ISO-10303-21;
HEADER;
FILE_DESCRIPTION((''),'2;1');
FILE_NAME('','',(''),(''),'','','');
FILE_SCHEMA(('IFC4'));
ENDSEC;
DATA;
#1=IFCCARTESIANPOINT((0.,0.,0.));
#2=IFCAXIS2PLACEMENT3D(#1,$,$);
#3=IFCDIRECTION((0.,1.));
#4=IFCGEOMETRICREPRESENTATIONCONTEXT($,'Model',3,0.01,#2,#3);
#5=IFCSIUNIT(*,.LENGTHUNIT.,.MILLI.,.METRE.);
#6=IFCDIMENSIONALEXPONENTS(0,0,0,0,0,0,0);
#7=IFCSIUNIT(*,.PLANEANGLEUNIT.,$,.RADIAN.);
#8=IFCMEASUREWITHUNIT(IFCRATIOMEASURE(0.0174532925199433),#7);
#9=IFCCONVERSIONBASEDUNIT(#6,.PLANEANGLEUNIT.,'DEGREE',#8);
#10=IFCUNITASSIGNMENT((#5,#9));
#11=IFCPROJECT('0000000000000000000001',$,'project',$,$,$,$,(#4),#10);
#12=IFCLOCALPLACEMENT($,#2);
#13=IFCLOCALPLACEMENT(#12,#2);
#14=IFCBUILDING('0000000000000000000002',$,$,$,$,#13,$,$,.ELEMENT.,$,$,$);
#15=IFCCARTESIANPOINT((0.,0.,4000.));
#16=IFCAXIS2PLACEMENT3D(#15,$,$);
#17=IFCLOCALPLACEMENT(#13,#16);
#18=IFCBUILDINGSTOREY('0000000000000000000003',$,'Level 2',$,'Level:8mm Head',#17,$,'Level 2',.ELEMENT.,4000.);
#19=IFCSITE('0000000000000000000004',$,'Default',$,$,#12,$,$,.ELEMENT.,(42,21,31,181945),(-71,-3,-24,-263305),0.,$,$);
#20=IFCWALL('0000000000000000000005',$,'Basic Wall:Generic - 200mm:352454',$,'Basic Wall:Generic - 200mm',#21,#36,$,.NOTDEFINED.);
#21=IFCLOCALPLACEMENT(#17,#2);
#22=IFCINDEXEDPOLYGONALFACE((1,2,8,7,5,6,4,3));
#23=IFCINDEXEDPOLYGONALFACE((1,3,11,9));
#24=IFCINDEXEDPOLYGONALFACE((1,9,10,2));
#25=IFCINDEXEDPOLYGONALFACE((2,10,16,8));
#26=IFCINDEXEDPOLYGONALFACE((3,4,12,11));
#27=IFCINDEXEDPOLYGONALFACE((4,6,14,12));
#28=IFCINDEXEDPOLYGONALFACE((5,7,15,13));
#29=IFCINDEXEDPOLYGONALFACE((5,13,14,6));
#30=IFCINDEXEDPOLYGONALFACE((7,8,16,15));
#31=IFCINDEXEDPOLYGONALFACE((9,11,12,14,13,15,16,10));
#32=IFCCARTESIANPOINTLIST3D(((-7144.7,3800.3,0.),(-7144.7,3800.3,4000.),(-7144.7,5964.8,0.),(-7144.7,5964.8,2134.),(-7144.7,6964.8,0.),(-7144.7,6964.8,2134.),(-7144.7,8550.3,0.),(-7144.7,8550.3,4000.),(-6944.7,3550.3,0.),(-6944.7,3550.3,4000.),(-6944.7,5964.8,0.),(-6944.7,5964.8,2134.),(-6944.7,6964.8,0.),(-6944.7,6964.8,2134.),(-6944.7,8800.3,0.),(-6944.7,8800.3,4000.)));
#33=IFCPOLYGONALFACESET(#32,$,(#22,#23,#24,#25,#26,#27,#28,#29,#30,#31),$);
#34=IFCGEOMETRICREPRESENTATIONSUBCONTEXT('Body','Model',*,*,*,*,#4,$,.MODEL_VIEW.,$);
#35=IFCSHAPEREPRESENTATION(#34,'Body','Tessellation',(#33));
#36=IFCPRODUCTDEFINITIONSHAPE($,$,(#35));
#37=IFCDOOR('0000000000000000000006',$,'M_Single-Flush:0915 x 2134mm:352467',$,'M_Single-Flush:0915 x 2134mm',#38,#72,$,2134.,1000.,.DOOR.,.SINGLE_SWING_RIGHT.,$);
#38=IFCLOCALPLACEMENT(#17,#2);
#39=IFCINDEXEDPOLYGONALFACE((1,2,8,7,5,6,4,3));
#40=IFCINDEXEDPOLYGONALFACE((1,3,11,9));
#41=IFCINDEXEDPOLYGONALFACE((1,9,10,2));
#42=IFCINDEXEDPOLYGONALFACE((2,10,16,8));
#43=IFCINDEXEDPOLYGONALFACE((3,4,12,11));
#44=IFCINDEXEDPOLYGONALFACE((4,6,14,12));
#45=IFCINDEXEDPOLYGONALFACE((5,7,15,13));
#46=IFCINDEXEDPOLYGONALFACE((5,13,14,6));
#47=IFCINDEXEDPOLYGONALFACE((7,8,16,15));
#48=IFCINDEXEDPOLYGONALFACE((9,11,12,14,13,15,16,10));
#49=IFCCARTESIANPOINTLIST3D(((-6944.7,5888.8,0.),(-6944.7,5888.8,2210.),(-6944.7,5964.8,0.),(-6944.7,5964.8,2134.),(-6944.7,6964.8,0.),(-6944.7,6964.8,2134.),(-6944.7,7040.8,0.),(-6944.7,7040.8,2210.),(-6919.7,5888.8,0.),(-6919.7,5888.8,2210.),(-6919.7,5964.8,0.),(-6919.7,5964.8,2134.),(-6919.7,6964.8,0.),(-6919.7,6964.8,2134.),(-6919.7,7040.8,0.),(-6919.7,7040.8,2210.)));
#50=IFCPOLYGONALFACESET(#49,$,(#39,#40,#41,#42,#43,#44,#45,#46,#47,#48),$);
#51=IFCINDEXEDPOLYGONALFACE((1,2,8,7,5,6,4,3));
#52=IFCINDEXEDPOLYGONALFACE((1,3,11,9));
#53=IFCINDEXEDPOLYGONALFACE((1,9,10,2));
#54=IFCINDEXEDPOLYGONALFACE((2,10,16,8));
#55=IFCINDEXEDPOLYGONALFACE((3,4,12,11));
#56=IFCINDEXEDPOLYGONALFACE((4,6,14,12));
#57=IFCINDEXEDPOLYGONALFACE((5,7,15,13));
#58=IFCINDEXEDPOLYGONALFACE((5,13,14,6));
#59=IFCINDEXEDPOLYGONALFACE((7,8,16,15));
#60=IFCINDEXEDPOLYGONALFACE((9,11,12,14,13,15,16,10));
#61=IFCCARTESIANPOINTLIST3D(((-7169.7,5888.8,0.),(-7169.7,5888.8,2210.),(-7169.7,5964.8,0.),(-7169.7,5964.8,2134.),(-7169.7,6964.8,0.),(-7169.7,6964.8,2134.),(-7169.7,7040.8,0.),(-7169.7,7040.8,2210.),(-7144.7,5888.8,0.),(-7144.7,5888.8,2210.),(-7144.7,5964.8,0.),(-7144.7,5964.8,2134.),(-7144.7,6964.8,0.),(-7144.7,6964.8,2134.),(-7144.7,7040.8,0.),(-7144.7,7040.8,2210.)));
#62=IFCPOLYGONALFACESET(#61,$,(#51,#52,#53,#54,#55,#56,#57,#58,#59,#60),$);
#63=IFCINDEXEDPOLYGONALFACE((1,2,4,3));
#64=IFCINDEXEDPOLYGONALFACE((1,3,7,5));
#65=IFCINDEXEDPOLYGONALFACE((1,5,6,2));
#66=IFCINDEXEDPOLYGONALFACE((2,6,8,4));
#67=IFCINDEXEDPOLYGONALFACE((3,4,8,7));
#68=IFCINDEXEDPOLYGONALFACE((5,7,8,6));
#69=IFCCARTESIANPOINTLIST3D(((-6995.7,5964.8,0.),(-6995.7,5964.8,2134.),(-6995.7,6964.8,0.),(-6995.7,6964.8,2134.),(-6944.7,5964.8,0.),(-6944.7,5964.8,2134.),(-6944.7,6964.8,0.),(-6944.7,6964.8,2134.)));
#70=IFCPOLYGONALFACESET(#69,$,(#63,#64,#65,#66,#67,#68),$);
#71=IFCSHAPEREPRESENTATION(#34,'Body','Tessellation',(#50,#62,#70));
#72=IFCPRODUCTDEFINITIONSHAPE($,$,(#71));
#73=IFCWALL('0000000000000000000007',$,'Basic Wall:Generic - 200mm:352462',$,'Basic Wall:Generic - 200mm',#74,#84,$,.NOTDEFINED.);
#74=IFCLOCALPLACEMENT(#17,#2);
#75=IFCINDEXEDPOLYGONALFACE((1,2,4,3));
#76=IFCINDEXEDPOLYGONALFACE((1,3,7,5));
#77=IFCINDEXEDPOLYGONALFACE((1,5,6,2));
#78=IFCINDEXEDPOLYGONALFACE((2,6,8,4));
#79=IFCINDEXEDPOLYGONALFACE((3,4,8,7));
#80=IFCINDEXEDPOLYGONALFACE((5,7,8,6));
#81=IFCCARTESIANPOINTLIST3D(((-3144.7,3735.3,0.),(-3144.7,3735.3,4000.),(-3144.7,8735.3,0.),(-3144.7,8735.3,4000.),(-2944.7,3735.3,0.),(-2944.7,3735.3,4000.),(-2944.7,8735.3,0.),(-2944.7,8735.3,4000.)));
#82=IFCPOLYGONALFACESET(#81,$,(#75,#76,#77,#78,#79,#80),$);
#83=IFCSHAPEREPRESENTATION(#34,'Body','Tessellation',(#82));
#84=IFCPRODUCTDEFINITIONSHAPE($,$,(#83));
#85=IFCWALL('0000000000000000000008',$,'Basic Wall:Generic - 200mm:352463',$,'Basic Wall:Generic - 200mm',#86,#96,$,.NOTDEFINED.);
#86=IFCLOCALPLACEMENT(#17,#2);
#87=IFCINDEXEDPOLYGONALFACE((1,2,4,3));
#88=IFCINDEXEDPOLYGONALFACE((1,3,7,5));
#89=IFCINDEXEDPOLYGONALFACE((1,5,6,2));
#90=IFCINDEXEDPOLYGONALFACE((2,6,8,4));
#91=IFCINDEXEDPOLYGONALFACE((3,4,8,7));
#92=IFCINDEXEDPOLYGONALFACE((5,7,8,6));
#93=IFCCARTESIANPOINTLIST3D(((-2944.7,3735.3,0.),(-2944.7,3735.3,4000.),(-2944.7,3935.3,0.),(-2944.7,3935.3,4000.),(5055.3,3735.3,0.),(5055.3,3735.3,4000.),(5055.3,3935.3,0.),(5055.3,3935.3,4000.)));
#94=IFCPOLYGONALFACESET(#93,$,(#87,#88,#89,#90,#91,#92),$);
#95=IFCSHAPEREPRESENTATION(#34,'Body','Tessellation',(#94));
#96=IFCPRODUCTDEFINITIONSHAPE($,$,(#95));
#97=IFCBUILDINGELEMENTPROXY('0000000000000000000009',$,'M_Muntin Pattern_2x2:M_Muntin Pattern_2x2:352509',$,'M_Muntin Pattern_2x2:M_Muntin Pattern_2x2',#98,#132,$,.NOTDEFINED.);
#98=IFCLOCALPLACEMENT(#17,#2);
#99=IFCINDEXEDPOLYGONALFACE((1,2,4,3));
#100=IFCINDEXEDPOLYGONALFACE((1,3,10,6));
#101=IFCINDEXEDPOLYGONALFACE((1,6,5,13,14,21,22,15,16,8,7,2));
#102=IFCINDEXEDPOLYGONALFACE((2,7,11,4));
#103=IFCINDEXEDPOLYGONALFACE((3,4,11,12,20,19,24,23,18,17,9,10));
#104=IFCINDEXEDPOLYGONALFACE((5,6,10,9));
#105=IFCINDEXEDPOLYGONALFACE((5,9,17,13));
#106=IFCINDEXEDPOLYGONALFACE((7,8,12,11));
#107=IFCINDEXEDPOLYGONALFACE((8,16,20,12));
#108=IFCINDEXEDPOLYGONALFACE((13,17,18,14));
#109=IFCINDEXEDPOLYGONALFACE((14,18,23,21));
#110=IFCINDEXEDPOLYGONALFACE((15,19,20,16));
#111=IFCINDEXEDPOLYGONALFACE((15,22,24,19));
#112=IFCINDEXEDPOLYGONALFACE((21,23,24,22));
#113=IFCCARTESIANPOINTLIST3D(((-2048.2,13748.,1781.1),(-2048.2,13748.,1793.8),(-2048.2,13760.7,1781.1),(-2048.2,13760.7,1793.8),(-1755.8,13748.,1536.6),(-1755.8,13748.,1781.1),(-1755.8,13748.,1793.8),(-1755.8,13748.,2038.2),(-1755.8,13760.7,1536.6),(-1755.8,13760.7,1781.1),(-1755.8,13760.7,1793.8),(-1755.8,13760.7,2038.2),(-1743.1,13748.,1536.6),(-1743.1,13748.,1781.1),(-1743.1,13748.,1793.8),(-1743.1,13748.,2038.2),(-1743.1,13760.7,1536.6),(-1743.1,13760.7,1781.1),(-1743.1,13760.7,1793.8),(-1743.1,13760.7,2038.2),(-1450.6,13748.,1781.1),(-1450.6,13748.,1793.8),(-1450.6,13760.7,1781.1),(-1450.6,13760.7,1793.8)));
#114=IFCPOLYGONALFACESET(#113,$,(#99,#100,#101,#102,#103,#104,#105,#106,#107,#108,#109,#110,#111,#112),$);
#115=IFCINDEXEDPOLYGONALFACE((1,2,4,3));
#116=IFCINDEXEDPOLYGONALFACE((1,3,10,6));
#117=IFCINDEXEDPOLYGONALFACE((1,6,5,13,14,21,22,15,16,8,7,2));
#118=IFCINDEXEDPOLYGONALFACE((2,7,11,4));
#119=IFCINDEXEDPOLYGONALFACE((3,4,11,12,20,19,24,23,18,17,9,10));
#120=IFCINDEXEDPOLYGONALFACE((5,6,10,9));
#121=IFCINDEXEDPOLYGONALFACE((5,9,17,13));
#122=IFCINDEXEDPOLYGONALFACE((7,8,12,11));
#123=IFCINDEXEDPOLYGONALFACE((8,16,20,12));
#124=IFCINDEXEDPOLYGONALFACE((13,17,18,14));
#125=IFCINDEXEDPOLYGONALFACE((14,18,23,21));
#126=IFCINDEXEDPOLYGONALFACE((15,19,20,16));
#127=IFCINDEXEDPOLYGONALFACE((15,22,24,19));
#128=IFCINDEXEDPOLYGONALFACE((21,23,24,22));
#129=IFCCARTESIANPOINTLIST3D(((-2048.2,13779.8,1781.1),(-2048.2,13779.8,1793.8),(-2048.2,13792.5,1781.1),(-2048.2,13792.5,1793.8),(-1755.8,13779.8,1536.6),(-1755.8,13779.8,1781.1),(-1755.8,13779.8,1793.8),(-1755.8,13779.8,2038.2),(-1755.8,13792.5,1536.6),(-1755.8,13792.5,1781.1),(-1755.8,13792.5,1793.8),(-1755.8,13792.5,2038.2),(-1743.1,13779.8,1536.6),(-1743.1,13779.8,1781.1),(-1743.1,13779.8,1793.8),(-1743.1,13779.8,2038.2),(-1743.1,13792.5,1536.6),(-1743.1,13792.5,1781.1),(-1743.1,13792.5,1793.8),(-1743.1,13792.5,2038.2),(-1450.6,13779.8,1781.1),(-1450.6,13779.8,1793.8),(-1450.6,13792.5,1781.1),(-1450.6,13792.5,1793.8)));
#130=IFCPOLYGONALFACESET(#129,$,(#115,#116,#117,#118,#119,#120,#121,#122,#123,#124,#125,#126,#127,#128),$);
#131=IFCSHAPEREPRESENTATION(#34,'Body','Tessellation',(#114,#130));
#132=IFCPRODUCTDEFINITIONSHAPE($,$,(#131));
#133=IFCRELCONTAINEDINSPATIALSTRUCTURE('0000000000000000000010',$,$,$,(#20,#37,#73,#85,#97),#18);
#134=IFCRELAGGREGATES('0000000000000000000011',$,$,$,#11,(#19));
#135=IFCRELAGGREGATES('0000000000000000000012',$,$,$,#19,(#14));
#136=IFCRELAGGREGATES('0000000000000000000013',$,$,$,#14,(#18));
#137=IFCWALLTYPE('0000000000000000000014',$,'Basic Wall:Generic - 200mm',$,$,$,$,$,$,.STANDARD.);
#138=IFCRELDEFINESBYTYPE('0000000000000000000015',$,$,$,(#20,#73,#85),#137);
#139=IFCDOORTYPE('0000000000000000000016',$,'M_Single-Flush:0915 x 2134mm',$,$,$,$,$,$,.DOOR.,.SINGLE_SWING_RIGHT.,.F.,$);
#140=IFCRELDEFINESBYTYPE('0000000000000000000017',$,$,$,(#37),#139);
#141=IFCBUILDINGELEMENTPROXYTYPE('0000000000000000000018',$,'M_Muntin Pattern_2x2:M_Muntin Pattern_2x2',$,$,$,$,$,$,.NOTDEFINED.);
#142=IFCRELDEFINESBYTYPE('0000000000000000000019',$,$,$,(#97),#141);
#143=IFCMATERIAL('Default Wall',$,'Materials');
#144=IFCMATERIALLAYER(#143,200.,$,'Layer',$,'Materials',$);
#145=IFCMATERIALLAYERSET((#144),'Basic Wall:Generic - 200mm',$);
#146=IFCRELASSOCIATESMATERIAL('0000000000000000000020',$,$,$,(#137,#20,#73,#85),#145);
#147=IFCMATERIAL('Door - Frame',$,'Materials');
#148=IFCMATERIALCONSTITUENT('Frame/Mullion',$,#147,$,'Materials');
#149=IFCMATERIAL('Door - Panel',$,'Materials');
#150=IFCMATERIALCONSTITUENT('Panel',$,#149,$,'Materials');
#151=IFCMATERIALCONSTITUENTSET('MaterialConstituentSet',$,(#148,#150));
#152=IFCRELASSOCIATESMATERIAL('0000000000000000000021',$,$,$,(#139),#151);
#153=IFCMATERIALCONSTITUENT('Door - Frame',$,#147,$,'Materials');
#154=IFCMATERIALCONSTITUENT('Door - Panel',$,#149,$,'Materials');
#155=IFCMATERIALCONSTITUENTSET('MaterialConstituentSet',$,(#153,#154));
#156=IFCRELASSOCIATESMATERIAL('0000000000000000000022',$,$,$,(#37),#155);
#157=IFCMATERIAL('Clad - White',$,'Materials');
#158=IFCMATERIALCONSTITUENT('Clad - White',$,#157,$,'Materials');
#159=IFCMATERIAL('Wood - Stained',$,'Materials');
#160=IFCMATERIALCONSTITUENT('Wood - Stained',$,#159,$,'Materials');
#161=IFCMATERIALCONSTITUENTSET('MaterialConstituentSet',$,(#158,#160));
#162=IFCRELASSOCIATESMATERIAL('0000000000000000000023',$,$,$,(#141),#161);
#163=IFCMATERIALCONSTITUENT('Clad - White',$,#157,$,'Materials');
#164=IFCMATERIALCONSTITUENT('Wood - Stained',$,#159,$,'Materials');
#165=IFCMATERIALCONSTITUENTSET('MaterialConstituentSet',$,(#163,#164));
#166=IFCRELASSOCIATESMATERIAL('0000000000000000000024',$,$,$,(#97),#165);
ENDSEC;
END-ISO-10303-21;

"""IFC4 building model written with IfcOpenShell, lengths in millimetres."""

from ifc_helpers import new_model, entity, si_unit, converted_unit, direction, frame, frame_2d, origin, place, context, subcontext, project, spatial, polyline, rectangle, outline, extrude, source, transform, mapped, material, layer, layer_set, layer_usage, constituent, constituent_set, type_object, type_shapes, element, fill, save


model = new_model("IFC4")

# Units and contexts
model_context = context("Model", 3, precision=0.01, world=origin(), true_north=direction((0.0, 1.0)))
body_context = subcontext(model_context, "Body", "Model", "MODEL_VIEW")
ifc_project = project(units=[si_unit("LENGTHUNIT", "METRE", prefix="MILLI"), converted_unit("PLANEANGLEUNIT", "DEGREE", entity("IfcRatioMeasure", 0.0174532925199433), si_unit("PLANEANGLEUNIT", "RADIAN"), dimensions=[0, 0, 0, 0, 0, 0, 0])], contexts=[model_context])

# Site, building, storey
site_placement = place(None, origin())
site = spatial("IfcSite", under=ifc_project, at=site_placement, Name="Default", CompositionType="ELEMENT", RefLatitude=(42, 21, 31, 181945), RefLongitude=(-71, -3, -24, -263305), RefElevation=0.0)
building_placement = place(site_placement, origin())
building = spatial("IfcBuilding", under=site, at=building_placement, CompositionType="ELEMENT")
storey_placement = place(building_placement, frame((0.0, 0.0, 4000.0)))
storey = spatial("IfcBuildingStorey", under=building, at=storey_placement, Name="Level 2", ObjectType="Level:8mm Head", LongName="Level 2", CompositionType="ELEMENT", Elevation=4000.0)

# Shared definitions
ifc_material_1 = material(Name="Default Wall", Category="Materials")
ifc_layer = layer(ifc_material_1, 200.0, Name="Layer", Category="Materials")
ifc_layer_set = layer_set([ifc_layer], Name="Basic Wall:Generic - 200mm")
wall_type = type_object("IfcWallType", Name="Basic Wall:Generic - 200mm", PredefinedType="STANDARD", material=ifc_layer_set)
ifc_material_2 = material(Name="Door - Frame", Category="Materials")
ifc_material_3 = material(Name="Door - Panel", Category="Materials")
ifc_constituent_1 = constituent(ifc_material_2, Name="Frame/Mullion", Category="Materials")
ifc_constituent_2 = constituent(ifc_material_3, Name="Panel", Category="Materials")
ifc_constituent_set_1 = constituent_set(constituents=[ifc_constituent_1, ifc_constituent_2], Name="MaterialConstituentSet")
door_type = type_object("IfcDoorType", Name="M_Single-Flush:0915 x 2134mm", OperationType="SINGLE_SWING_RIGHT", ParameterTakesPrecedence=False, PredefinedType="DOOR", material=ifc_constituent_set_1)
shared_shape_1 = source(origin(), body_context, "Body", "SweptSolid", [
    extrude(outline(polyline([(-576.0, -1124.0), (576.0, -1124.0), (576.0, 1086.0), (500.0, 1086.0), (500.0, -1048.0), (-500.0, -1048.0), (-500.0, 1086.0), (-576.0, 1086.0), (-576.0, -1124.0)])), frame((500.0, 200.0, 1086.0), z_axis=(0.0, 1.0, 0.0), x_axis=(1.0, 0.0, 0.0)), (0.0, 0.0, 1.0), 25.0),
    extrude(outline(polyline([(-1124.0, -576.0), (1086.0, -576.0), (1086.0, -500.0), (-1048.0, -500.0), (-1048.0, 500.0), (1086.0, 500.0), (1086.0, 576.0), (-1124.0, 576.0), (-1124.0, -576.0)])), frame((500.0, -25.0, 1086.0), z_axis=(0.0, 1.0, 0.0), x_axis=(0.0, 0.0, -1.0)), (0.0, 0.0, 1.0), 25.0),
    extrude(rectangle(XDim=51.0, YDim=1000.0, at=frame_2d((0.0, 0.0), x_axis=(1.0, 0.0))), frame((500.0, 174.5, 0.0), z_axis=(0.0, 0.0, 1.0), x_axis=(0.0, 1.0, 0.0)), (0.0, 0.0, 1.0), 2134.0),
])
type_shapes(door_type, [shared_shape_1])
ifc_material_4 = material(Name="Wood - Stained", Category="Materials")

# Wall, opening, door
ifc_layer_usage_1 = layer_usage(ifc_layer_set, "AXIS2", "NEGATIVE", 100.0)
wall_1_placement = place(storey_placement, frame((-7044.7, 8800.3, 0.0), z_axis=(0.0, 0.0, 1.0), x_axis=(0.0, -1.0, 0.0)))
wall_1 = element("IfcWall", 1, at=wall_1_placement, inside=storey, type_object=wall_type, material=ifc_layer_usage_1, Name="Basic Wall:Generic - 200mm:352454", ObjectType="Basic Wall:Generic - 200mm", PredefinedType="NOTDEFINED", context=body_context, shape_type="SweptSolid", body=[
    extrude(outline(polyline([(250.0, -100.0), (5000.0, -100.0), (5250.0, 100.0), (4929.8, 100.0), (0.0, 100.0), (250.0, -100.0)])), origin(), (0.0, 0.0, 1.0), 4000.0),
])
opening_1_placement = place(wall_1_placement, frame((1835.4, -100.0, 0.0)))
opening_1 = element("IfcOpeningElement", 2, at=opening_1_placement, cuts=wall_1, PredefinedType="OPENING", context=body_context, shape_type="SweptSolid", body=[
    extrude(rectangle(XDim=1000.0, YDim=2134.0, at=frame_2d((1067.0, 500.0), x_axis=(0.0, 1.0))), frame((0.0, 0.0, 0.0), z_axis=(0.0, 1.0, 0.0), x_axis=(0.0, 0.0, 1.0)), (0.0, 0.0, 1.0), 200.0),
])
ifc_constituent_3 = constituent(ifc_material_2, Name="Door - Frame", Category="Materials")
ifc_constituent_4 = constituent(ifc_material_3, Name="Door - Panel", Category="Materials")
ifc_constituent_set_2 = constituent_set(constituents=[ifc_constituent_3, ifc_constituent_4], Name="MaterialConstituentSet")
door_1_placement = place(opening_1_placement, origin())
door_1 = element("IfcDoor", 3, at=door_1_placement, inside=storey, type_object=door_type, material=ifc_constituent_set_2, Name="M_Single-Flush:0915 x 2134mm:352467", ObjectType="M_Single-Flush:0915 x 2134mm", OperationType="SINGLE_SWING_RIGHT", OverallHeight=2134.0, OverallWidth=1000.0, PredefinedType="DOOR", context=body_context, shape_type="MappedRepresentation", body=[
    mapped(shared_shape_1, transform((0.0, 0.0, 0.0), scale=1.0)),
])
fill(opening_1, door_1)

# Walls
ifc_layer_usage_2 = layer_usage(ifc_layer_set, "AXIS2", "NEGATIVE", 100.0)
wall_2_placement = place(storey_placement, frame((-3044.7, 8735.3, 0.0), z_axis=(0.0, 0.0, 1.0), x_axis=(0.0, -1.0, 0.0)))
element("IfcWall", 4, at=wall_2_placement, inside=storey, type_object=wall_type, material=ifc_layer_usage_2, Name="Basic Wall:Generic - 200mm:352462", ObjectType="Basic Wall:Generic - 200mm", PredefinedType="NOTDEFINED", context=body_context, shape_type="SweptSolid", body=[
    extrude(rectangle(XDim=5000.0, YDim=200.0, at=frame_2d((2500.0, 0.0), x_axis=(-1.0, 0.0))), origin(), (0.0, 0.0, 1.0), 4000.0),
])
ifc_layer_usage_3 = layer_usage(ifc_layer_set, "AXIS2", "NEGATIVE", 100.0)
wall_3_placement = place(storey_placement, frame((-2944.7, 3835.3, 0.0)))
element("IfcWall", 5, at=wall_3_placement, inside=storey, type_object=wall_type, material=ifc_layer_usage_3, Name="Basic Wall:Generic - 200mm:352463", ObjectType="Basic Wall:Generic - 200mm", PredefinedType="NOTDEFINED", context=body_context, shape_type="SweptSolid", body=[
    extrude(rectangle(XDim=8000.0, YDim=200.0, at=frame_2d((4000.0, 0.0), x_axis=(-1.0, 0.0))), origin(), (0.0, 0.0, 1.0), 4000.0),
])

# Building element proxy
ifc_material_5 = material(Name="Clad - White", Category="Materials")
ifc_constituent_5 = constituent(ifc_material_5, Name="Clad - White", Category="Materials")
ifc_constituent_6 = constituent(ifc_material_4, Name="Wood - Stained", Category="Materials")
ifc_constituent_set_3 = constituent_set(constituents=[ifc_constituent_5, ifc_constituent_6], Name="MaterialConstituentSet")
ifc_constituent_7 = constituent(ifc_material_5, Name="Clad - White", Category="Materials")
ifc_constituent_8 = constituent(ifc_material_4, Name="Wood - Stained", Category="Materials")
ifc_constituent_set_4 = constituent_set(constituents=[ifc_constituent_7, ifc_constituent_8], Name="MaterialConstituentSet")
building_element_proxy_type_1 = type_object("IfcBuildingElementProxyType", Name="M_Muntin Pattern_2x2:M_Muntin Pattern_2x2", PredefinedType="NOTDEFINED", material=ifc_constituent_set_4)
shared_shape_2 = source(origin(), body_context, "Body", "SweptSolid", [
    extrude(outline(polyline([(6.4, -6.4), (250.8, -6.4), (250.8, 6.3), (6.4, 6.3), (6.4, 298.8), (-6.3, 298.8), (-6.3, 6.3), (-250.8, 6.3), (-250.8, -6.4), (-6.3, -6.4), (-6.3, -298.8), (6.4, -298.8), (6.4, -6.4)])), frame((0.0, 9.5, 250.8), z_axis=(0.0, 1.0, 0.0), x_axis=(0.0, 0.0, 1.0)), (0.0, 0.0, 1.0), 12.7),
    extrude(outline(polyline([(6.4, -6.4), (250.8, -6.4), (250.8, 6.3), (6.4, 6.3), (6.4, 298.8), (-6.3, 298.8), (-6.3, 6.3), (-250.8, 6.3), (-250.8, -6.4), (-6.3, -6.4), (-6.3, -298.8), (6.4, -298.8), (6.4, -6.4)])), frame((0.0, -22.2, 250.8), z_axis=(0.0, 1.0, 0.0), x_axis=(0.0, 0.0, 1.0)), (0.0, 0.0, 1.0), 12.7),
])
type_shapes(building_element_proxy_type_1, [shared_shape_2])
proxy_1_placement = place(storey_placement, frame((-1749.4, 13770.3, 1536.6), z_axis=(0.0, 0.0, 1.0), x_axis=(-1.0, 0.0, 0.0)))
element("IfcBuildingElementProxy", 6, at=proxy_1_placement, inside=storey, type_object=building_element_proxy_type_1, material=ifc_constituent_set_3, Name="M_Muntin Pattern_2x2:M_Muntin Pattern_2x2:352509", ObjectType="M_Muntin Pattern_2x2:M_Muntin Pattern_2x2", PredefinedType="NOTDEFINED", context=body_context, shape_type="MappedRepresentation", body=[
    mapped(shared_shape_2, transform((0.0, 0.0, 0.0), scale=1.0)),
])

save(model, "model.ifc")
